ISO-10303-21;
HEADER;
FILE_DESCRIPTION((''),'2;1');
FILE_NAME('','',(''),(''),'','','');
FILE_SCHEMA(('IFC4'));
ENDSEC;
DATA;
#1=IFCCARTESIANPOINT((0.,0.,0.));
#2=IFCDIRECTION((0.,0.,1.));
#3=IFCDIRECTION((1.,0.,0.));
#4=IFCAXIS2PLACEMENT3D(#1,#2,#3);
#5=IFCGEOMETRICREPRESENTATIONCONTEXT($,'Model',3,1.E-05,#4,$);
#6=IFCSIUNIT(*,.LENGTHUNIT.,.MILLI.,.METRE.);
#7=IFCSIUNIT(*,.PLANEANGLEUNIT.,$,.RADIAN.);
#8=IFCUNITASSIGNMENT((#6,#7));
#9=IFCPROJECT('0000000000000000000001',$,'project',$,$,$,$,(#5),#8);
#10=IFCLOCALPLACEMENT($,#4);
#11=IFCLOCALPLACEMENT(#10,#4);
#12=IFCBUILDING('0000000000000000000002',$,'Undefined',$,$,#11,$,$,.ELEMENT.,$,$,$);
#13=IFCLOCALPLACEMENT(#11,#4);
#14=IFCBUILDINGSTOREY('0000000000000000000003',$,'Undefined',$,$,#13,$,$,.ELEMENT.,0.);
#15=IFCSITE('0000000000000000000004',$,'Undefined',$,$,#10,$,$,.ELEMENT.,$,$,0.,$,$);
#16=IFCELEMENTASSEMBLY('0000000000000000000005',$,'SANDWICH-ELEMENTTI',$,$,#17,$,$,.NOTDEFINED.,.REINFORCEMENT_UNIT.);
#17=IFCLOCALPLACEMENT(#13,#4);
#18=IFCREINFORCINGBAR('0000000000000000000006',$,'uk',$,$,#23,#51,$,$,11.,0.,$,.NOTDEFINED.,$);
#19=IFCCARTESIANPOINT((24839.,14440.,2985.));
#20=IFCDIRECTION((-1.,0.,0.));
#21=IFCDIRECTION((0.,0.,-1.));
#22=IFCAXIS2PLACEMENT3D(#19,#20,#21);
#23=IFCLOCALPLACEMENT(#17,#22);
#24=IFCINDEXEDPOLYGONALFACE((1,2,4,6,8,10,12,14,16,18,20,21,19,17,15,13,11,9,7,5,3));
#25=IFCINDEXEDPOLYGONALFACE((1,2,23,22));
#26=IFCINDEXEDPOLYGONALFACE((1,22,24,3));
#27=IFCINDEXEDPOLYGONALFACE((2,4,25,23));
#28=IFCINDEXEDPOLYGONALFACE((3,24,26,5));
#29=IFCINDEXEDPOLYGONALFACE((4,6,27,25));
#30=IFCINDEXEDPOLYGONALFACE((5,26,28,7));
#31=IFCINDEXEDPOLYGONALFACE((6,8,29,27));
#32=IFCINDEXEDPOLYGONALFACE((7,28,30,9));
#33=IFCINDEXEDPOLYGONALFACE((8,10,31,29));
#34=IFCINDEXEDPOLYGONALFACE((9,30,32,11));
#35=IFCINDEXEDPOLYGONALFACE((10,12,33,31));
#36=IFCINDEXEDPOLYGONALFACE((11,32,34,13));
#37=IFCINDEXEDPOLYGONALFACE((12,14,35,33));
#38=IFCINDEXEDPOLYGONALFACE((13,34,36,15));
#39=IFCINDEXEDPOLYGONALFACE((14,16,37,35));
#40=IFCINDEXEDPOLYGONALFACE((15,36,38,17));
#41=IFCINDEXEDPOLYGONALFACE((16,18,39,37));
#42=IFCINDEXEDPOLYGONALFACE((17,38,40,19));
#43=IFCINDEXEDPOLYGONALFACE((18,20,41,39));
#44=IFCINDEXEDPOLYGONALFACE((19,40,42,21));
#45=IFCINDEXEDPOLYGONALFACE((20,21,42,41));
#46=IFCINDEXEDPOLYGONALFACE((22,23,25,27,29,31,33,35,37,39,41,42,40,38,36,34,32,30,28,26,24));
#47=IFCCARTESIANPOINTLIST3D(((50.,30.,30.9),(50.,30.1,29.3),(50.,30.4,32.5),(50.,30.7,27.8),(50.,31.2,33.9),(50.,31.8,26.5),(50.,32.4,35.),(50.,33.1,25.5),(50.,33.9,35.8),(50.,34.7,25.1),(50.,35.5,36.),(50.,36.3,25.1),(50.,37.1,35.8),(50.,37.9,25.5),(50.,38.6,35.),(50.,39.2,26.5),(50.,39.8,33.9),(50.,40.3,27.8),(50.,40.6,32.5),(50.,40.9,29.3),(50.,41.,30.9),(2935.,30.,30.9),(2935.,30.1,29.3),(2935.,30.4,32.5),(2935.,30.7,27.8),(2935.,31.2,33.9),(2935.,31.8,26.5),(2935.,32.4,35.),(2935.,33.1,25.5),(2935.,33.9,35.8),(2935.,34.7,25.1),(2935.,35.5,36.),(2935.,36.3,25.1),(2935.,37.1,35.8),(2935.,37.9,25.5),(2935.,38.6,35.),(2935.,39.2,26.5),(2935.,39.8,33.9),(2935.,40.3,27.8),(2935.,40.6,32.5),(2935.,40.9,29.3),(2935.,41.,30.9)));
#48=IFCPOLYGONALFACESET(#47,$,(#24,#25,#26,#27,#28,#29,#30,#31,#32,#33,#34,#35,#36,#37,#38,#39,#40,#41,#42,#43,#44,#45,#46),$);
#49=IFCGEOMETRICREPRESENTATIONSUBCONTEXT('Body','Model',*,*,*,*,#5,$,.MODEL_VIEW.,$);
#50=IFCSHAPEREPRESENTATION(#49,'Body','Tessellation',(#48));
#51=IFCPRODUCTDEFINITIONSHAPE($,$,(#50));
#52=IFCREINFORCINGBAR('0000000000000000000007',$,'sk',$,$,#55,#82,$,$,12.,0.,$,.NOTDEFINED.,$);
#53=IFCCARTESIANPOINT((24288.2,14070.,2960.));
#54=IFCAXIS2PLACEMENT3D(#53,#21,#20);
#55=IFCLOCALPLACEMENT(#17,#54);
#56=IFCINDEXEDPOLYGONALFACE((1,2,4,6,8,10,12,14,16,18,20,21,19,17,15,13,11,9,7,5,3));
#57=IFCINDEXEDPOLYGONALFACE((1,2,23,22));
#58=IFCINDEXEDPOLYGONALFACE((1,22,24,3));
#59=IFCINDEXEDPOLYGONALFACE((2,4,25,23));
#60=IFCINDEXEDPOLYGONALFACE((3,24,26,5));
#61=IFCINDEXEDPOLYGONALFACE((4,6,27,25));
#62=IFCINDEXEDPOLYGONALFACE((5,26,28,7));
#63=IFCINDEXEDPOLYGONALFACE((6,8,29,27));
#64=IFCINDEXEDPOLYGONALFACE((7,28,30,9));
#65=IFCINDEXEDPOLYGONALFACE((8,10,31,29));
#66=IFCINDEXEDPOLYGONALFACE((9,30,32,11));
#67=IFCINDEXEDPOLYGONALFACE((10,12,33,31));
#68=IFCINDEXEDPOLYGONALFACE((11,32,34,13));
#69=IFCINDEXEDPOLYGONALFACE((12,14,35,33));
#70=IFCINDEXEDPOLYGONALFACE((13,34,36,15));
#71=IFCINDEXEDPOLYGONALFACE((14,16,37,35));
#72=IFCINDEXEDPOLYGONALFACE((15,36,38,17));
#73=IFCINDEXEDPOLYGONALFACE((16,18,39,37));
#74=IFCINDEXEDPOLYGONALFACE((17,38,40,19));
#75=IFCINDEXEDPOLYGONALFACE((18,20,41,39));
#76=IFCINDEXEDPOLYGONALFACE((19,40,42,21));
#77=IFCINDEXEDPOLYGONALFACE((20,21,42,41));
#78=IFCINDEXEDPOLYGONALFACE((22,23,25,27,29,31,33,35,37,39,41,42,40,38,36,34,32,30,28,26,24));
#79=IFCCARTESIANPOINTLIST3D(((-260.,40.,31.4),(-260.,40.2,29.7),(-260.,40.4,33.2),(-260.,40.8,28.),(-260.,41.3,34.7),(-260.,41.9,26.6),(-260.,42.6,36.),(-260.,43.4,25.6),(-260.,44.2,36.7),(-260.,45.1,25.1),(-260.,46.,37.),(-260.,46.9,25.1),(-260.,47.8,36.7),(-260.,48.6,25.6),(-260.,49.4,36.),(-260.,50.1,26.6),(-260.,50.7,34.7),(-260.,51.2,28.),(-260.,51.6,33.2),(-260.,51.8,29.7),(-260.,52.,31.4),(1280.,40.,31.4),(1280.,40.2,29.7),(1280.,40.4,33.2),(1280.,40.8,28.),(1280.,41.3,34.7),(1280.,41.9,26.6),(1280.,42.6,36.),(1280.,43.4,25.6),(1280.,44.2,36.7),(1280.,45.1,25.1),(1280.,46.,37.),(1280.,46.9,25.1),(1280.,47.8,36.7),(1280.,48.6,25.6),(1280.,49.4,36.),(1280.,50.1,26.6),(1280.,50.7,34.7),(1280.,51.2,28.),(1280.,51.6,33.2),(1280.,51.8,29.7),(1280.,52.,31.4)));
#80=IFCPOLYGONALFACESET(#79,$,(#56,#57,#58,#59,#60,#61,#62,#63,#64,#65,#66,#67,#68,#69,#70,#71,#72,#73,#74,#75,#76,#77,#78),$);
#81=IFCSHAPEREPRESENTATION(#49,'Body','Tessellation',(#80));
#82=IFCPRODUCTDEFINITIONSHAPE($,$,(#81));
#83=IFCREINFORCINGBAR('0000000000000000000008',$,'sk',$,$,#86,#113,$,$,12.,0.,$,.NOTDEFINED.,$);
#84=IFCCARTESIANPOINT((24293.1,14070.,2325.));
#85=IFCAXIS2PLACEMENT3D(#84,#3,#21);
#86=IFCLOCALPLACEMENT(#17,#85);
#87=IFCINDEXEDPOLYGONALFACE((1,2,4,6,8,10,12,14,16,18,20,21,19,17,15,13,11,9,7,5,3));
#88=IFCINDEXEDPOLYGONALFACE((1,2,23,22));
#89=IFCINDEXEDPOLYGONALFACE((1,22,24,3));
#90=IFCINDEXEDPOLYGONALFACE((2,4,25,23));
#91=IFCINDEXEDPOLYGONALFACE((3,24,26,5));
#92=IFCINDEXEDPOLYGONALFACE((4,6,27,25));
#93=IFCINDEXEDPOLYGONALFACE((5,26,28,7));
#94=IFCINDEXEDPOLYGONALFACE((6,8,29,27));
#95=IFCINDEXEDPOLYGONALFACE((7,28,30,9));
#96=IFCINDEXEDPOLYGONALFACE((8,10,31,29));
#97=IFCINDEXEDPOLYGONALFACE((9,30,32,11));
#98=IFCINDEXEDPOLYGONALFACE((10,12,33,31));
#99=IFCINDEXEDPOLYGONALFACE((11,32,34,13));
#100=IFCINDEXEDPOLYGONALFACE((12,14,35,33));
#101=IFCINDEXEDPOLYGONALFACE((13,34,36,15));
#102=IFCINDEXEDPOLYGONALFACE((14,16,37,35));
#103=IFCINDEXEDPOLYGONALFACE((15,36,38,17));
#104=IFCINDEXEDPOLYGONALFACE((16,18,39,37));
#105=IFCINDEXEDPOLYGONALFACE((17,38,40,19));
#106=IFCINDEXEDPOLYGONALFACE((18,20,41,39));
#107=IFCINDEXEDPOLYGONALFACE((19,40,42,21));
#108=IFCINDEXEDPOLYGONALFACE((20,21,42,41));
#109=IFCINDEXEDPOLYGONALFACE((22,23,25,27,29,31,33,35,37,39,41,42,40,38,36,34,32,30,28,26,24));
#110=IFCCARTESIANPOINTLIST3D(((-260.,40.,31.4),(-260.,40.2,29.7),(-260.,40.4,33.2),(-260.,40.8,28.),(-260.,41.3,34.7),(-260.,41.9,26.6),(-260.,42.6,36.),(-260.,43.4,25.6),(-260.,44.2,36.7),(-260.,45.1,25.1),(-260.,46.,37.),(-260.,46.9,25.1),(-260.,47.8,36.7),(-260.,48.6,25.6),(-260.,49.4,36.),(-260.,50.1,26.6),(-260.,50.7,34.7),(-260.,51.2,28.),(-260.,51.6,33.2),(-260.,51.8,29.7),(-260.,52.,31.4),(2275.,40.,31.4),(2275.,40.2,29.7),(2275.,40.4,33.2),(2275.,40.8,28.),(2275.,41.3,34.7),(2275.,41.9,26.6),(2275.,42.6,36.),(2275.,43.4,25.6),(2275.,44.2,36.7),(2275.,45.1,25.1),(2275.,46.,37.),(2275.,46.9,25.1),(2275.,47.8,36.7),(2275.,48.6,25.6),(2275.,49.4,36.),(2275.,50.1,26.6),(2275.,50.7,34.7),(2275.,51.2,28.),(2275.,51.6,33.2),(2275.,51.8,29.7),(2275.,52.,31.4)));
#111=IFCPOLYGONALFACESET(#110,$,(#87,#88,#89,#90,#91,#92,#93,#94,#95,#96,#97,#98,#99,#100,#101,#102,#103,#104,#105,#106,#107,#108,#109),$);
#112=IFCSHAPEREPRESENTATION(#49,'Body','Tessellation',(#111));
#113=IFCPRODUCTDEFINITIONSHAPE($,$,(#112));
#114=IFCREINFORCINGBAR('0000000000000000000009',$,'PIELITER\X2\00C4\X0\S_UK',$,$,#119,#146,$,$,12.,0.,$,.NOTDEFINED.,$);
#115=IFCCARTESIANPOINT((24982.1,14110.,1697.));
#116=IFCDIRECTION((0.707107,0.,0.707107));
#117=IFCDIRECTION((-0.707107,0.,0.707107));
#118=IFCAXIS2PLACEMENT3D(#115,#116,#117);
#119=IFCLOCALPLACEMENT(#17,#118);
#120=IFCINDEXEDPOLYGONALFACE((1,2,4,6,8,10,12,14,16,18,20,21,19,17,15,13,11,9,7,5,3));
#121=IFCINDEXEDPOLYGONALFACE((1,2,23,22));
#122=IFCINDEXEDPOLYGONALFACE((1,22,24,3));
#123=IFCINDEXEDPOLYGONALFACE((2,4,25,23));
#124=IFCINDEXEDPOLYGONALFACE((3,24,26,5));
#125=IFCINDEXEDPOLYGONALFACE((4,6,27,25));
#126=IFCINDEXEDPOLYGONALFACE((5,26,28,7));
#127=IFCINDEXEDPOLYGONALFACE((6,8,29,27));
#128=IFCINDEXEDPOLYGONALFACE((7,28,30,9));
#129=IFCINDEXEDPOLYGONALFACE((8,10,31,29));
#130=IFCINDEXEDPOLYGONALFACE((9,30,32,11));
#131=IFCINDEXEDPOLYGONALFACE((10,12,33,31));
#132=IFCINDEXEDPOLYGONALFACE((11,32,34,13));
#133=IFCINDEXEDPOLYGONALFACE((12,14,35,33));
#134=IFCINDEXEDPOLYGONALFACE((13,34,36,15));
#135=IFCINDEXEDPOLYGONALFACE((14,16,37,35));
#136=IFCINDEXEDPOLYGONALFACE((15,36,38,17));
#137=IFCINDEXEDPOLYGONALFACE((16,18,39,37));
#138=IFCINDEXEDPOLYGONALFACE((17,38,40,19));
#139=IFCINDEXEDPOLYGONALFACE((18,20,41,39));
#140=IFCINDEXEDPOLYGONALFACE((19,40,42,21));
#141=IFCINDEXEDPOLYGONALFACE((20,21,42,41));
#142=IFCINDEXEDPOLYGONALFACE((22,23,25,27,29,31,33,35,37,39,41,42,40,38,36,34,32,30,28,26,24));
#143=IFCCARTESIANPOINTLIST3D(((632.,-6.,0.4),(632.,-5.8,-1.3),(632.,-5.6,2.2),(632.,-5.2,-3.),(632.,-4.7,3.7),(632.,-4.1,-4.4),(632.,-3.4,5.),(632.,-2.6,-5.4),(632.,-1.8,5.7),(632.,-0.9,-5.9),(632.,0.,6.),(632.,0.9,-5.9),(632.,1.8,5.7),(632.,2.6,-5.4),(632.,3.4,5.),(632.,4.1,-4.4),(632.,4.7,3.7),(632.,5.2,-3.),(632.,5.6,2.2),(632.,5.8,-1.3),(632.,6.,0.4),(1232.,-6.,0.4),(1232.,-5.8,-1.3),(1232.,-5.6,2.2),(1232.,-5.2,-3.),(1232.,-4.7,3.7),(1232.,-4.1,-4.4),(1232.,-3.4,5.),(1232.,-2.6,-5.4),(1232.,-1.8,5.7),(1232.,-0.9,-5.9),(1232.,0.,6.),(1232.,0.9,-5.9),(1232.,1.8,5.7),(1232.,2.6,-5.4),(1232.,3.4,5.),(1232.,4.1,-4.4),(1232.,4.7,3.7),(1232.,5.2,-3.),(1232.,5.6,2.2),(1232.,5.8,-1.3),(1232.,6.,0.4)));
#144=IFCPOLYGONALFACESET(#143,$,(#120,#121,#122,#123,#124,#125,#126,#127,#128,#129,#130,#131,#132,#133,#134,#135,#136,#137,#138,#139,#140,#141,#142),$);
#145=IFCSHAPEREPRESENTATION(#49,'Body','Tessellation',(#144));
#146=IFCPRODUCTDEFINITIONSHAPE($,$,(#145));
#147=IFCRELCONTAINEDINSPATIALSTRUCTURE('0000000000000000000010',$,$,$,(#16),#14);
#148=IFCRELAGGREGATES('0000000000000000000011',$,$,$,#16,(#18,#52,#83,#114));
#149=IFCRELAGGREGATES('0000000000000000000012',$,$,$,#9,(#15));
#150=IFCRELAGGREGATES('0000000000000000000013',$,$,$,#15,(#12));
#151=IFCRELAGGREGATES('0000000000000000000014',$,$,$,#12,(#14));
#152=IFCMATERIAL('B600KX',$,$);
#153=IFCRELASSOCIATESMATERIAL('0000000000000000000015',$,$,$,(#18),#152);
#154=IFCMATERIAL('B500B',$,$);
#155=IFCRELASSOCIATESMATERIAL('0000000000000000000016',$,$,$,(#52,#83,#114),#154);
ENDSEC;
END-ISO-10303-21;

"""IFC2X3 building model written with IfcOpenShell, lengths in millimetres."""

from ifc_helpers import new_model, entity, si_unit, frame, origin_with_axes, place, context, subcontext, project, spatial, source, transform, mapped, material, element, aggregate, save


model = new_model("IFC2X3")

# Units and contexts
model_context = context("Model", 3, precision=1e-05, world=origin_with_axes())
body_context = subcontext(model_context, "Body", "Model", "MODEL_VIEW")
ifc_project = project(units=[si_unit("LENGTHUNIT", "METRE", prefix="MILLI"), si_unit("PLANEANGLEUNIT", "RADIAN")], contexts=[model_context])

# Site, building, storey
site_placement = place(None, origin_with_axes())
site = spatial("IfcSite", under=ifc_project, at=site_placement, Name="Undefined", CompositionType="ELEMENT", RefElevation=0.0)
building_placement = place(site_placement, origin_with_axes())
building = spatial("IfcBuilding", under=site, at=building_placement, Name="Undefined", CompositionType="ELEMENT")
storey_placement = place(building_placement, origin_with_axes())
storey = spatial("IfcBuildingStorey", under=building, at=storey_placement, Name="Undefined", CompositionType="ELEMENT", Elevation=0.0)

# Element assembly
assembly_1_placement = place(storey_placement, origin_with_axes())
assembly_1 = element("IfcElementAssembly", 1, at=assembly_1_placement, inside=storey, Name="SANDWICH-ELEMENTTI", AssemblyPlace="NOTDEFINED", PredefinedType="REINFORCEMENT_UNIT")

# Reinforcing bars
ifc_material_1 = material(Name="B600KX")
shared_shape_1 = source(origin_with_axes(), body_context, "Body", "AdvancedSweptSolid", [
    entity("IfcSweptDiskSolid", entity("IfcTrimmedCurve", entity("IfcLine", entity("IfcCartesianPoint", [0.0, 0.0, 0.0]), entity("IfcVector", entity("IfcDirection", [1.0, 0.0, 0.0]), 1.0)), [entity("IfcParameterValue", 0.0)], [entity("IfcParameterValue", 2885.0004)], True, "PARAMETER"), 5.5, None, 0.0, 2885.0),
])
reinforcing_bar_1_placement = place(assembly_1_placement, frame((24839.0, 14440.0, 2985.0), z_axis=(-1.0, 0.0, 0.0), x_axis=(0.0, 0.0, -1.0)))
reinforcing_bar_1 = element("IfcReinforcingBar", 2, at=reinforcing_bar_1_placement, material=ifc_material_1, Name="uk", BarRole="NOTDEFINED", CrossSectionArea=0.0, NominalDiameter=11.0, context=body_context, shape_type="MappedRepresentation", body=[
    mapped(shared_shape_1, transform((50.0, 35.5, 30.5))),
])
ifc_material_2 = material(Name="B500B")
shared_shape_2 = source(origin_with_axes(), body_context, "Body", "AdvancedSweptSolid", [
    entity("IfcSweptDiskSolid", entity("IfcTrimmedCurve", entity("IfcLine", entity("IfcCartesianPoint", [0.0, 0.0, 0.0]), entity("IfcVector", entity("IfcDirection", [1.0, 0.0, 0.0]), 1.0)), [entity("IfcParameterValue", 0.0)], [entity("IfcParameterValue", 1540.0342)], True, "PARAMETER"), 6.0, None, 0.0, 1540.0),
])
reinforcing_bar_2_placement = place(assembly_1_placement, frame((24288.2, 14070.0, 2960.0), z_axis=(0.0, 0.0, -1.0), x_axis=(-1.0, 0.0, 0.0)))
reinforcing_bar_2 = element("IfcReinforcingBar", 3, at=reinforcing_bar_2_placement, material=ifc_material_2, Name="sk", BarRole="NOTDEFINED", CrossSectionArea=0.0, NominalDiameter=12.0, context=body_context, shape_type="MappedRepresentation", body=[
    mapped(shared_shape_2, transform((-260.0, 46.0, 31.0))),
])
shared_shape_3 = source(origin_with_axes(), body_context, "Body", "AdvancedSweptSolid", [
    entity("IfcSweptDiskSolid", entity("IfcTrimmedCurve", entity("IfcLine", entity("IfcCartesianPoint", [0.0, 0.0, 0.0]), entity("IfcVector", entity("IfcDirection", [1.0, 0.0, 0.0]), 1.0)), [entity("IfcParameterValue", 0.0)], [entity("IfcParameterValue", 2534.9997)], True, "PARAMETER"), 6.0, None, 0.0, 2535.0),
])
reinforcing_bar_3_placement = place(assembly_1_placement, frame((24293.1, 14070.0, 2325.0), z_axis=(1.0, 0.0, 0.0), x_axis=(0.0, 0.0, -1.0)))
reinforcing_bar_3 = element("IfcReinforcingBar", 4, at=reinforcing_bar_3_placement, material=ifc_material_2, Name="sk", BarRole="NOTDEFINED", CrossSectionArea=0.0, NominalDiameter=12.0, context=body_context, shape_type="MappedRepresentation", body=[
    mapped(shared_shape_3, transform((-260.0, 46.0, 31.0))),
])
shared_shape_4 = source(origin_with_axes(), body_context, "Body", "AdvancedSweptSolid", [
    entity("IfcSweptDiskSolid", entity("IfcTrimmedCurve", entity("IfcLine", entity("IfcCartesianPoint", [0.0, 0.0, 0.0]), entity("IfcVector", entity("IfcDirection", [1.0, 0.0, 0.0]), 1.0)), [entity("IfcParameterValue", 0.0)], [entity("IfcParameterValue", 600.0)], True, "PARAMETER"), 6.0, None, 0.0, 600.0),
])
reinforcing_bar_4_placement = place(assembly_1_placement, frame((24982.1, 14110.0, 1697.0), z_axis=(0.707107, 0.0, 0.707107), x_axis=(-0.707107, 0.0, 0.707107)))
reinforcing_bar_4 = element("IfcReinforcingBar", 5, at=reinforcing_bar_4_placement, material=ifc_material_2, Name="PIELITERÄS_UK", BarRole="NOTDEFINED", CrossSectionArea=0.0, NominalDiameter=12.0, context=body_context, shape_type="MappedRepresentation", body=[
    mapped(shared_shape_4, transform((632.0, 0.0, 0.0))),
])
aggregate(assembly_1, [reinforcing_bar_1, reinforcing_bar_2, reinforcing_bar_3, reinforcing_bar_4])

save(model, "model.ifc")
